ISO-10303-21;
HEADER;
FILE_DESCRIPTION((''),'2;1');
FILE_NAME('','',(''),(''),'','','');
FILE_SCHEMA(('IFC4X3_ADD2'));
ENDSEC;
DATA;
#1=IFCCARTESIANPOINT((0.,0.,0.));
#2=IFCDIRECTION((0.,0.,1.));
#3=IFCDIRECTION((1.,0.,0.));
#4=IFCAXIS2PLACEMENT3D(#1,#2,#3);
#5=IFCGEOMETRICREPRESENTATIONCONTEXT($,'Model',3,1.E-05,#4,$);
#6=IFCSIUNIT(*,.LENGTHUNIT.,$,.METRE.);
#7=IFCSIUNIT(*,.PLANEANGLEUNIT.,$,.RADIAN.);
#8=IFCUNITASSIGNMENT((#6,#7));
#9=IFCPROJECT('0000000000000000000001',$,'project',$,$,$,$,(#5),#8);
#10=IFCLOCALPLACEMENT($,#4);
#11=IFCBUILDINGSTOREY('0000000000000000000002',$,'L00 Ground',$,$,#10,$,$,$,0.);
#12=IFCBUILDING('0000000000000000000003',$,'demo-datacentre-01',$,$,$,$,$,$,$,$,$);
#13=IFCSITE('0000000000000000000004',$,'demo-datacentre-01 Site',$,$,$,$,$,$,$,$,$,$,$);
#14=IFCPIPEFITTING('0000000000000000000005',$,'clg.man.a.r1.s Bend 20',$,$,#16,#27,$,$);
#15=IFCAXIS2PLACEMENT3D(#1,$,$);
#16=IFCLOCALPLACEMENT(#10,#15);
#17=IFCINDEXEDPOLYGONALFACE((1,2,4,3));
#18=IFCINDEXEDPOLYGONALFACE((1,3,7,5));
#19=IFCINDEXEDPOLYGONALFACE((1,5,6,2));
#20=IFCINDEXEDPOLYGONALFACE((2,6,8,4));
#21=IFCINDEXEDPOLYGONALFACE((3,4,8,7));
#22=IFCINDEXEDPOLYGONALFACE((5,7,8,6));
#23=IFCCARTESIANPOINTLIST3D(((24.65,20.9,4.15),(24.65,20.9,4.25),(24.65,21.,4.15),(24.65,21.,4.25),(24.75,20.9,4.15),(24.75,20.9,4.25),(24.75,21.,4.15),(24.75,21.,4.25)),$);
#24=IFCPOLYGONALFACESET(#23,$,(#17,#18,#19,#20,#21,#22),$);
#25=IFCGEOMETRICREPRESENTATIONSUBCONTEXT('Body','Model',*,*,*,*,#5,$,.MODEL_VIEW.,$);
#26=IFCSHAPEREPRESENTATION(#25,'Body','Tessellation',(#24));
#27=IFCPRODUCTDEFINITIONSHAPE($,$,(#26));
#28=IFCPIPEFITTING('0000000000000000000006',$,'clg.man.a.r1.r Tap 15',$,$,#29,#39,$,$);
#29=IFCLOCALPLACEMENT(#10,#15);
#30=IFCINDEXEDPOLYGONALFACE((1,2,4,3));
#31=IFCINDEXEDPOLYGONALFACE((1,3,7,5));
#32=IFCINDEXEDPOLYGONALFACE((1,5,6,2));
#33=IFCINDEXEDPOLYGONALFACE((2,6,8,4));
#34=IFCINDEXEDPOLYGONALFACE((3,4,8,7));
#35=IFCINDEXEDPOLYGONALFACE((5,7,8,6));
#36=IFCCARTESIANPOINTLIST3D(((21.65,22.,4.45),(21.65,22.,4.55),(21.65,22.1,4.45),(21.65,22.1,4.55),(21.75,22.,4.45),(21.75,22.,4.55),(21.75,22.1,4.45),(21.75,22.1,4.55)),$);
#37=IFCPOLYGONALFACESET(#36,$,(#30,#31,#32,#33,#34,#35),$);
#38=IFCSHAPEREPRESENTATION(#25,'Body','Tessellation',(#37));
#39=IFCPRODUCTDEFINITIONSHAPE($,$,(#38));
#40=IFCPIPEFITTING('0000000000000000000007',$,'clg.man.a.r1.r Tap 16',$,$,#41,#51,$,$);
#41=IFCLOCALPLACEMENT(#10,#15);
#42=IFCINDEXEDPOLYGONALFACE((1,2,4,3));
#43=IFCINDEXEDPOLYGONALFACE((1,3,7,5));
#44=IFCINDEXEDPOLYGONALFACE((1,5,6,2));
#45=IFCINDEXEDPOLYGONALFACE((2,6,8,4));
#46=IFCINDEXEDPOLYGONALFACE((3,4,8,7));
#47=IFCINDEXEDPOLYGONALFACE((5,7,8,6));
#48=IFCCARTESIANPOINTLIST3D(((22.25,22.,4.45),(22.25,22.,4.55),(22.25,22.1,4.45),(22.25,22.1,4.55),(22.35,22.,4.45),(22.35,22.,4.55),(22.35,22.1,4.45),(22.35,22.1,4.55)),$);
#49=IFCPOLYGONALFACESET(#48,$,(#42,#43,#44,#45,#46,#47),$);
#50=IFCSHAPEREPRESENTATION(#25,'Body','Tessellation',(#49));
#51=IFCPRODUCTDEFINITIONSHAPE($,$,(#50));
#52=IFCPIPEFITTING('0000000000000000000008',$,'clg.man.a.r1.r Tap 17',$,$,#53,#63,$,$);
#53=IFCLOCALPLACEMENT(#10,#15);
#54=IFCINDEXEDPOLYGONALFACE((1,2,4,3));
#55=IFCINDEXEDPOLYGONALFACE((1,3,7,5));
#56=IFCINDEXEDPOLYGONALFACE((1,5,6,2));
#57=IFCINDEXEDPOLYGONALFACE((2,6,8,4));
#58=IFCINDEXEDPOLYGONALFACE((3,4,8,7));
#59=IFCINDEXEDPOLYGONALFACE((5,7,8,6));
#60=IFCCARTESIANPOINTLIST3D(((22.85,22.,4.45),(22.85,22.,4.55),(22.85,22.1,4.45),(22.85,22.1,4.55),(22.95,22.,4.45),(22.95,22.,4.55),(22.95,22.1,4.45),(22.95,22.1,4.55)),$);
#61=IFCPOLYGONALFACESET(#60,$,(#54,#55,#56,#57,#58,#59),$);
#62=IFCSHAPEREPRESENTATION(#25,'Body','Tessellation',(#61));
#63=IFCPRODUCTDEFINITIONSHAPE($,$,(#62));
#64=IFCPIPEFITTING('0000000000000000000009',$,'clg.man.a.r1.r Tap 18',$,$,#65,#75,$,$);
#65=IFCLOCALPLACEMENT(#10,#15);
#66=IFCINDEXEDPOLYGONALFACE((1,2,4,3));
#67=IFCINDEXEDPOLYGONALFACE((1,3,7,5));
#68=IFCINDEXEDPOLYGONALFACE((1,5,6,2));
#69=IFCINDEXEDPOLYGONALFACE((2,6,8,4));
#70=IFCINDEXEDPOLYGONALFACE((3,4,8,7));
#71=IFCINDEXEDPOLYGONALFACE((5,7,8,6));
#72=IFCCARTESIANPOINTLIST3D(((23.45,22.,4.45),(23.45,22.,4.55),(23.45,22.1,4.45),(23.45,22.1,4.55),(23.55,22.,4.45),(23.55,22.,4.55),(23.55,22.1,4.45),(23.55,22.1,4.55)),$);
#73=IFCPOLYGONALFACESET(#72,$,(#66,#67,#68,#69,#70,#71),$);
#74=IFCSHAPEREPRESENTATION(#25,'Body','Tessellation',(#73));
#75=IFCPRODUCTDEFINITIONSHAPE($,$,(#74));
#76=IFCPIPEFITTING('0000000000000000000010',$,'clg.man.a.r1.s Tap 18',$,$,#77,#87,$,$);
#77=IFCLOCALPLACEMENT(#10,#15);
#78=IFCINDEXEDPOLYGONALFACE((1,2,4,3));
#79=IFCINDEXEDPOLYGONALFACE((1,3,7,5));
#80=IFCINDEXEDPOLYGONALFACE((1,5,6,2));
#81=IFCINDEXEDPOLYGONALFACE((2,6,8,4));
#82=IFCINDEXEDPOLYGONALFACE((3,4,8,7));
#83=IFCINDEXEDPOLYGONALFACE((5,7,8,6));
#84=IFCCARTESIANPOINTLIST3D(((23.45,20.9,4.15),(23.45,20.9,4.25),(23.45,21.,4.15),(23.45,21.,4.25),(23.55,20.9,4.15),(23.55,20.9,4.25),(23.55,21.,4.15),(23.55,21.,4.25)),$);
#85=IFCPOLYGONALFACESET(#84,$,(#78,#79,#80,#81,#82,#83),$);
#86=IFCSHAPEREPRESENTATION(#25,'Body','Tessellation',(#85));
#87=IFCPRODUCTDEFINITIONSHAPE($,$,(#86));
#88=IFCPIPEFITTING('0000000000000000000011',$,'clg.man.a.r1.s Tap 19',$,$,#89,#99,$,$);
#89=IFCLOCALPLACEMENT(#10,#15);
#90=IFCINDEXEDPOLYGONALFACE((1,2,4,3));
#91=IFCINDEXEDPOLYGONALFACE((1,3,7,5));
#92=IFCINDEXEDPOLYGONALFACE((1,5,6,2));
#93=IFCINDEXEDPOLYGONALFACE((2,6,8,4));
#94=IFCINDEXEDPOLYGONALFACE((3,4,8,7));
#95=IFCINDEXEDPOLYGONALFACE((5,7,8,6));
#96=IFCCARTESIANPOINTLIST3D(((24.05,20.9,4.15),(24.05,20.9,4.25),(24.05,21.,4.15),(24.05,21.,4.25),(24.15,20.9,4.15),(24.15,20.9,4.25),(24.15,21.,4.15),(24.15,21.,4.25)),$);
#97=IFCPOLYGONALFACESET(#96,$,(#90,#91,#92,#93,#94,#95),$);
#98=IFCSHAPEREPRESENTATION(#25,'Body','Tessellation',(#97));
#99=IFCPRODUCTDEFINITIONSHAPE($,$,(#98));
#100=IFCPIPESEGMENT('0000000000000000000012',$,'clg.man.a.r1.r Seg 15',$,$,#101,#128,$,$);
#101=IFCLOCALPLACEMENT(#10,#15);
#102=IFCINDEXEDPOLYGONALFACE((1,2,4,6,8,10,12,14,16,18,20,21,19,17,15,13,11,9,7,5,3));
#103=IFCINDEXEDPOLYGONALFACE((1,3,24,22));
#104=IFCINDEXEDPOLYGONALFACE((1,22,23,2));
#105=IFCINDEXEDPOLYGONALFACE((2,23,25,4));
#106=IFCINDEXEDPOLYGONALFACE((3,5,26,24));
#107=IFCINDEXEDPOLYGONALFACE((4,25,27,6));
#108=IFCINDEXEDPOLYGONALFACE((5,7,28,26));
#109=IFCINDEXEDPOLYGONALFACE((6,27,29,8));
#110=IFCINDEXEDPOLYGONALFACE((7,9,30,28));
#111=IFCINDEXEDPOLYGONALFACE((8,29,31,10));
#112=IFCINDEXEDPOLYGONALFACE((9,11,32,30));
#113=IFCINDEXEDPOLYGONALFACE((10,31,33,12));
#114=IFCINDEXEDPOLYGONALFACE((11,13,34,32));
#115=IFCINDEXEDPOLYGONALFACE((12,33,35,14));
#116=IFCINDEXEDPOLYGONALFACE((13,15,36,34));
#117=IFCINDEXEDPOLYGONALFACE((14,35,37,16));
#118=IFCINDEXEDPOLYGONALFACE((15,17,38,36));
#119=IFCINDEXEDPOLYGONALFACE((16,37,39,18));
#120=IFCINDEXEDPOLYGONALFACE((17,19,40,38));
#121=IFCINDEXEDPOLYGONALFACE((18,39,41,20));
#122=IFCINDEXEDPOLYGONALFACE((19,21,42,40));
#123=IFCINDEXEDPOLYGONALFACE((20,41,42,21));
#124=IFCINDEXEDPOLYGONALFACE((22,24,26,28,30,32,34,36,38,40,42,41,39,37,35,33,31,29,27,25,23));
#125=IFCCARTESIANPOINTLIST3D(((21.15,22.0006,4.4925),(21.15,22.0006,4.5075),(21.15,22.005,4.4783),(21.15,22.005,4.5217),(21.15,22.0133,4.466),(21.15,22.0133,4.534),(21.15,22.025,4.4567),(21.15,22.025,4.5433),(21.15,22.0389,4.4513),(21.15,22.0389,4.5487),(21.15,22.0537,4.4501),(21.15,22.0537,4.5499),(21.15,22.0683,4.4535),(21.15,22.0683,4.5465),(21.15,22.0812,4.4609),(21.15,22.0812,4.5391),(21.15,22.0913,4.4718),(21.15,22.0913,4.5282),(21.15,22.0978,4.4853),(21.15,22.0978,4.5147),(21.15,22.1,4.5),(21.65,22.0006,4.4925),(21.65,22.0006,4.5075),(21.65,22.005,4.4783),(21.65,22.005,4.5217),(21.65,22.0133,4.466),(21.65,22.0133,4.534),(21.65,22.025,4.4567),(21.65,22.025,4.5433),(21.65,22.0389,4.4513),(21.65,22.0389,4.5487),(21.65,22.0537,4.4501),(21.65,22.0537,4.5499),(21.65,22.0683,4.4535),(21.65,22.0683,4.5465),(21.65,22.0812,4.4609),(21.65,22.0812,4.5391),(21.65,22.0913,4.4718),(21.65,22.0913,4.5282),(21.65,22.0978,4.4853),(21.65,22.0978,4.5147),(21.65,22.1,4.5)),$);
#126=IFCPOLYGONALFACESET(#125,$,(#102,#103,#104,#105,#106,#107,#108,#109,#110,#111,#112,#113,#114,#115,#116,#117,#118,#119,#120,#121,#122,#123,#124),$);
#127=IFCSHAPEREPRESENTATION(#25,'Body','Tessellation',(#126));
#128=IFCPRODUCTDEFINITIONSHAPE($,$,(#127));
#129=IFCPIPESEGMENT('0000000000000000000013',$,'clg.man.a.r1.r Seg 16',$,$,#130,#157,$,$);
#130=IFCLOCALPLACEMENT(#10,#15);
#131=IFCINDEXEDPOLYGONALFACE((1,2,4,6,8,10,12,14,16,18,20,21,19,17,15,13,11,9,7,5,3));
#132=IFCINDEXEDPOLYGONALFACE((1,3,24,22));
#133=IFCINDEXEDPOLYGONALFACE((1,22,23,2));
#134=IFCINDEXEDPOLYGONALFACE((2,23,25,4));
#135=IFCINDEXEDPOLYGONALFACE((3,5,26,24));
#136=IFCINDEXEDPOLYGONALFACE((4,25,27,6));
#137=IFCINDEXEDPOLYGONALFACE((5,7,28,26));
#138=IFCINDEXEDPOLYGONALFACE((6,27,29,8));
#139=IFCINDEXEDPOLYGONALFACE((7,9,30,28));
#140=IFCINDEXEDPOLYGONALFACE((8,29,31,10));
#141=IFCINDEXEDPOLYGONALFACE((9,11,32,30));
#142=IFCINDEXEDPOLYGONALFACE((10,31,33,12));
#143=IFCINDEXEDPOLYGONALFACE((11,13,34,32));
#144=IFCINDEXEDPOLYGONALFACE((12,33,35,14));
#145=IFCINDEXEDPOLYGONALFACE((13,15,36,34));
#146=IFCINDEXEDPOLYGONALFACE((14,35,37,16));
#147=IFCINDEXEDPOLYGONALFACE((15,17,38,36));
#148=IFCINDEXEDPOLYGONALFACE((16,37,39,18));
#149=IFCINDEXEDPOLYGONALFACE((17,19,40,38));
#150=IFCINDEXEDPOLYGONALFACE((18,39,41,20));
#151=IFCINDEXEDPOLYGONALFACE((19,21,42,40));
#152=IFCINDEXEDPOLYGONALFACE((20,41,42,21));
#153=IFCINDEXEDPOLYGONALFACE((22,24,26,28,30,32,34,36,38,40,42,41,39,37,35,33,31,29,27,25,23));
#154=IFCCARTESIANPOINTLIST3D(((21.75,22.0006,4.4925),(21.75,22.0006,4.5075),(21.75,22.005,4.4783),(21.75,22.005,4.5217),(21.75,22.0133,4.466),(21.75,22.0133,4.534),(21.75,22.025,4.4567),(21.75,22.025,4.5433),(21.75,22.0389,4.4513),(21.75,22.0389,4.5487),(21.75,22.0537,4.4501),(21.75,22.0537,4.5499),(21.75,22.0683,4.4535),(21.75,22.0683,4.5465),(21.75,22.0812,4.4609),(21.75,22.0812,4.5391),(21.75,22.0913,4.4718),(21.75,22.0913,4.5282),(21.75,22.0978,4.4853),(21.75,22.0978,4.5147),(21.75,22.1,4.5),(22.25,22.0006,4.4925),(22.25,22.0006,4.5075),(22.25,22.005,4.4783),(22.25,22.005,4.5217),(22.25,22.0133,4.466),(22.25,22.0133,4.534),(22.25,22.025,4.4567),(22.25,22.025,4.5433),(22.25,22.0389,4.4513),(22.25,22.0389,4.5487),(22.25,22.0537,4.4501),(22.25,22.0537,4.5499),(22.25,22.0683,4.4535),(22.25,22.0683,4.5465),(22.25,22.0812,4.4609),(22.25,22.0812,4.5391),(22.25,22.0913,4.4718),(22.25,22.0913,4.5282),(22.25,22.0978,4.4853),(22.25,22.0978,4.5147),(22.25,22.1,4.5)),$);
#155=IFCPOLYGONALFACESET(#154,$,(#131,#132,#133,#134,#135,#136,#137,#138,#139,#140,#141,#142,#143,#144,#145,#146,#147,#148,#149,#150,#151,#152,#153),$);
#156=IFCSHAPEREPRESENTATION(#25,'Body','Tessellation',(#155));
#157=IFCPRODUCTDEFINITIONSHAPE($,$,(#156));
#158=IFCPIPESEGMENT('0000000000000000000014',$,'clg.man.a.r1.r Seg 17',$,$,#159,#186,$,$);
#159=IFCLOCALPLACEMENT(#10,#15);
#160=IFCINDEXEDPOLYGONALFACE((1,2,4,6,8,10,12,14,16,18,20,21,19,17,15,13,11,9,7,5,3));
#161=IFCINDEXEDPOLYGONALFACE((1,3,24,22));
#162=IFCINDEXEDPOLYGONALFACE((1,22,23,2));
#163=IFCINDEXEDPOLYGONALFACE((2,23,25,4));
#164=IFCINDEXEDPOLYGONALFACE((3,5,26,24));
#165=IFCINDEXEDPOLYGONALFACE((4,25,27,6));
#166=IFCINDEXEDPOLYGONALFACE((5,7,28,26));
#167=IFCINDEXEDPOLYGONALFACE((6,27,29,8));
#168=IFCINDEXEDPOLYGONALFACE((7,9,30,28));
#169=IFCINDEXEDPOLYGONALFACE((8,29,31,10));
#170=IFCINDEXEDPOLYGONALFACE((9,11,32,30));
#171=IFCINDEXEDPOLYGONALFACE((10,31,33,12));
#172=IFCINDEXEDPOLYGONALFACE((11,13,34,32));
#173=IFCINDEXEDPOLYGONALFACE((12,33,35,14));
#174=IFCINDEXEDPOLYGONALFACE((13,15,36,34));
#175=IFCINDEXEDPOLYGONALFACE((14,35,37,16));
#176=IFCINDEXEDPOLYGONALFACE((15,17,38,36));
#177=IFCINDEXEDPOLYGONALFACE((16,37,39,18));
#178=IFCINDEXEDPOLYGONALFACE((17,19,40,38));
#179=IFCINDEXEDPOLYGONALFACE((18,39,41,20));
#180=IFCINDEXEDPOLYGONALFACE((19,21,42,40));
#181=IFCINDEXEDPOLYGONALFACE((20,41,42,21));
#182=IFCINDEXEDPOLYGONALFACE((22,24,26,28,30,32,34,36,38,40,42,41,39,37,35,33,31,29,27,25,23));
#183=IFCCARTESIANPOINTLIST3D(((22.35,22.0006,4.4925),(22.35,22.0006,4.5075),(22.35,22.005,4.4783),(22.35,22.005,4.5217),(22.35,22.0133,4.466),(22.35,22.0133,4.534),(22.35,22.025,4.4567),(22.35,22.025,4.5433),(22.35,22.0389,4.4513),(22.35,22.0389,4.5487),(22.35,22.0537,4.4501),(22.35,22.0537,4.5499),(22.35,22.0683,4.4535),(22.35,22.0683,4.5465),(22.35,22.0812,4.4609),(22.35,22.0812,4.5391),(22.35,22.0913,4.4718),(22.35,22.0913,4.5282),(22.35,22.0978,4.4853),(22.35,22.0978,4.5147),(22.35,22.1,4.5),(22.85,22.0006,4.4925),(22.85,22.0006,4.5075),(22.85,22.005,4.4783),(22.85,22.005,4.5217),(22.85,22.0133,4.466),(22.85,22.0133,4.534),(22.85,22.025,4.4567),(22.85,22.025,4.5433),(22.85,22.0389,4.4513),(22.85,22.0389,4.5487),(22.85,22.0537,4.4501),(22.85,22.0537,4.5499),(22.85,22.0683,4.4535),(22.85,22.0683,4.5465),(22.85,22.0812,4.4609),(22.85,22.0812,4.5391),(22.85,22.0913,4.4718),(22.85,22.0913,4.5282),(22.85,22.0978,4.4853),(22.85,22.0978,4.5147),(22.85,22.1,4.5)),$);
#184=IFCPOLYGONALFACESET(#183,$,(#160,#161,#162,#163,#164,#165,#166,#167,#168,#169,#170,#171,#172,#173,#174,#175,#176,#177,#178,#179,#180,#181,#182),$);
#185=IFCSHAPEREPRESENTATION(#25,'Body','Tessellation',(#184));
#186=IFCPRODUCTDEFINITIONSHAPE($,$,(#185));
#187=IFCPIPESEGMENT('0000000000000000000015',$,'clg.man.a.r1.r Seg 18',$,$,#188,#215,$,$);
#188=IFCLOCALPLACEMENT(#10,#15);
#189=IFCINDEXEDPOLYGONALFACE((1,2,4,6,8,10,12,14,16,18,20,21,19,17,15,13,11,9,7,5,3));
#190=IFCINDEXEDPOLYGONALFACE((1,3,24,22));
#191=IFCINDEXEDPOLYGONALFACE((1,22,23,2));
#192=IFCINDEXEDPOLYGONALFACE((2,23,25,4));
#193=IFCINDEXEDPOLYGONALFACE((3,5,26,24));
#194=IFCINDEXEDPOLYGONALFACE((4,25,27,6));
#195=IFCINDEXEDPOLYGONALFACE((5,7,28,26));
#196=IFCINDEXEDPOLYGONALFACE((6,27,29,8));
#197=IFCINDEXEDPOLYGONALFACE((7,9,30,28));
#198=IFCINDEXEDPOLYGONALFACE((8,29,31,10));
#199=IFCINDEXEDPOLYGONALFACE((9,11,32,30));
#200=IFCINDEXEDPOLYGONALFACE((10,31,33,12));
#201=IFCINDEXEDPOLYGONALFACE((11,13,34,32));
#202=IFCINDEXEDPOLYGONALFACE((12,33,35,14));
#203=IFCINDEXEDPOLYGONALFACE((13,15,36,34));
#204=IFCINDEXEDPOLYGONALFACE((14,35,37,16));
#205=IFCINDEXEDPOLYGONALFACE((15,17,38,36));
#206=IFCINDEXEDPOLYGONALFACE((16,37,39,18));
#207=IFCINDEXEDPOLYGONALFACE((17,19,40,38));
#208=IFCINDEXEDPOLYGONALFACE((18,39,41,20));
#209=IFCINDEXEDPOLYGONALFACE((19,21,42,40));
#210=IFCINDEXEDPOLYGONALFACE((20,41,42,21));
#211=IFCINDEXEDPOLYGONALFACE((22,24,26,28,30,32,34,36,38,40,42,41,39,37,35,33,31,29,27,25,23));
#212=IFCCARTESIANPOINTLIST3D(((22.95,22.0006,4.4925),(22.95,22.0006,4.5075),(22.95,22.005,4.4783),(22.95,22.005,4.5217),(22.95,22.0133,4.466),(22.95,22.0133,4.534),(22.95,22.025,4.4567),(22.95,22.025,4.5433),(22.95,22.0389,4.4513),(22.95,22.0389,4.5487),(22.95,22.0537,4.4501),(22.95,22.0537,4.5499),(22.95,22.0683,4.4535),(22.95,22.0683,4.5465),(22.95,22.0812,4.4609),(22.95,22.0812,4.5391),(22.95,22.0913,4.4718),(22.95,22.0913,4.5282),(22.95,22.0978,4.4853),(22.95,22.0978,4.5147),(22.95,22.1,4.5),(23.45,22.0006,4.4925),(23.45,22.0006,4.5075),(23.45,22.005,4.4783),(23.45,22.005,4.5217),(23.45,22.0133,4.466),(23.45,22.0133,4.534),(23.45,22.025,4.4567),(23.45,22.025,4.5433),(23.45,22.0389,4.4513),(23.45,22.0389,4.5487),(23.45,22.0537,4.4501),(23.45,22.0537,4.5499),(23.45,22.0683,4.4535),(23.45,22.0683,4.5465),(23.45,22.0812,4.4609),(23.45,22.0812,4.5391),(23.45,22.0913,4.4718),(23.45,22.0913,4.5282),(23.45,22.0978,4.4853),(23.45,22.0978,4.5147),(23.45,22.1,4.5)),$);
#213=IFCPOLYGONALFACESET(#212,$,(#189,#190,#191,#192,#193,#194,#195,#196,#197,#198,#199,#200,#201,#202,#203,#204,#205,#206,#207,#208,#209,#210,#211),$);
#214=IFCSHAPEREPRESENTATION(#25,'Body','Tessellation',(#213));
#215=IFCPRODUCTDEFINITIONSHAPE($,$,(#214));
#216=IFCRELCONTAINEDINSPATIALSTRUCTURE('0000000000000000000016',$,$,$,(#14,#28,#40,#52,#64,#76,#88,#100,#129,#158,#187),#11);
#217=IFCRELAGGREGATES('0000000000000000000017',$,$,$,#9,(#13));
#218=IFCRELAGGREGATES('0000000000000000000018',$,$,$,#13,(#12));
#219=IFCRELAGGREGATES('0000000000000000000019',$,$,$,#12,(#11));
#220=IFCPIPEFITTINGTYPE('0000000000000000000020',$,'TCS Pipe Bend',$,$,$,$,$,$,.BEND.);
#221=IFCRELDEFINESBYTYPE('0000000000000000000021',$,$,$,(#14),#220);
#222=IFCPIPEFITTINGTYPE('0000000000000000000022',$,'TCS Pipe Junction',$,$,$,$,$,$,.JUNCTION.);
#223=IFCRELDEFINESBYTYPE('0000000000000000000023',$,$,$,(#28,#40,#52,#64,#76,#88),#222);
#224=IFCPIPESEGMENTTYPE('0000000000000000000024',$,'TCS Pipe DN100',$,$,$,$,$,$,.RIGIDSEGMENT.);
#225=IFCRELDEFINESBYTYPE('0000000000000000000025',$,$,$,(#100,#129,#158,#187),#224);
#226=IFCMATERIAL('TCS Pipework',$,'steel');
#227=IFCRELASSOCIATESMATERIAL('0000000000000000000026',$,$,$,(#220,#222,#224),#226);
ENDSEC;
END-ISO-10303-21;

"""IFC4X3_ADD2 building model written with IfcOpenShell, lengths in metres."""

from ifc_helpers import new_model, si_unit, frame, origin_with_axes, place, context, subcontext, project, spatial, rectangle, circle, extrude, material, type_object, element, save


model = new_model("IFC4X3_ADD2")

# Units and contexts
model_context = context("Model", 3, precision=1e-05, world=origin_with_axes())
body_context = subcontext(model_context, "Body", "Model", "MODEL_VIEW")
ifc_project = project(units=[si_unit("LENGTHUNIT", "METRE"), si_unit("PLANEANGLEUNIT", "RADIAN")], contexts=[model_context])

# Site, building, storey
site = spatial("IfcSite", under=ifc_project, Name="demo-datacentre-01 Site")
building = spatial("IfcBuilding", under=site, Name="demo-datacentre-01")
storey_placement = place(None, origin_with_axes())
storey = spatial("IfcBuildingStorey", under=building, at=storey_placement, Name="L00 Ground", Elevation=0.0)

# Pipe fittings
ifc_material = material(Name="TCS Pipework", Category="steel")
pipe_fitting_type_1 = type_object("IfcPipeFittingType", Name="TCS Pipe Bend", PredefinedType="BEND", material=ifc_material)
pipe_fitting_placement = place(storey_placement, frame((24.7, 20.95, 4.15), z_axis=(0.0, 0.0, 1.0), x_axis=(1.0, 0.0, 0.0)))
element("IfcPipeFitting", 1, at=pipe_fitting_placement, inside=storey, type_object=pipe_fitting_type_1, Name="clg.man.a.r1.s Bend 20", context=body_context, shape_type="SweptSolid", body=[
    extrude(rectangle(XDim=0.1, YDim=0.1), origin_with_axes(), (0.0, 0.0, 1.0), 0.1),
])
pipe_fitting_type_2 = type_object("IfcPipeFittingType", Name="TCS Pipe Junction", PredefinedType="JUNCTION", material=ifc_material)
for number, where, z_axis, x_axis, name in (
    (2, (21.7, 22.05, 4.45), (0.0, 0.0, 1.0), (1.0, 0.0, 0.0), "clg.man.a.r1.r Tap 15"),
    (3, (22.3, 22.05, 4.45), (0.0, 0.0, 1.0), (1.0, 0.0, 0.0), "clg.man.a.r1.r Tap 16"),
    (4, (22.9, 22.05, 4.45), (0.0, 0.0, 1.0), (1.0, 0.0, 0.0), "clg.man.a.r1.r Tap 17"),
    (5, (23.5, 22.05, 4.45), (0.0, 0.0, 1.0), (1.0, 0.0, 0.0), "clg.man.a.r1.r Tap 18"),
    (6, (23.5, 20.95, 4.15), (0.0, 0.0, 1.0), (1.0, 0.0, 0.0), "clg.man.a.r1.s Tap 18"),
    (7, (24.1, 20.95, 4.15), (0.0, 0.0, 1.0), (1.0, 0.0, 0.0), "clg.man.a.r1.s Tap 19"),
):
    element("IfcPipeFitting", number, at=place(storey_placement, frame(where, z_axis=z_axis, x_axis=x_axis)), inside=storey, type_object=pipe_fitting_type_2, Name=name, context=body_context, shape_type="SweptSolid", body=[
        extrude(rectangle(XDim=0.1, YDim=0.1), origin_with_axes(), (0.0, 0.0, 1.0), 0.1),
    ])

# Pipe segments
pipe_segment_type_1 = type_object("IfcPipeSegmentType", Name="TCS Pipe DN100", PredefinedType="RIGIDSEGMENT", material=ifc_material)
pipe_segment_placement = place(storey_placement, frame((21.15, 22.05, 4.5), z_axis=(1.0, 0.0, 0.0), x_axis=(0.0, 1.0, 0.0)))
element("IfcPipeSegment", 8, at=pipe_segment_placement, inside=storey, type_object=pipe_segment_type_1, Name="clg.man.a.r1.r Seg 15", context=body_context, shape_type="SweptSolid", body=[
    extrude(circle(Radius=0.05), origin_with_axes(), (0.0, 0.0, 1.0), 0.5),
])
for number, where, z_axis, x_axis, name in (
    (9, (21.75, 22.05, 4.5), (1.0, 0.0, 0.0), (0.0, 1.0, 0.0), "clg.man.a.r1.r Seg 16"),
    (10, (22.35, 22.05, 4.5), (1.0, 0.0, 0.0), (0.0, 1.0, 0.0), "clg.man.a.r1.r Seg 17"),
):
    element("IfcPipeSegment", number, at=place(storey_placement, frame(where, z_axis=z_axis, x_axis=x_axis)), inside=storey, type_object=pipe_segment_type_1, Name=name, context=body_context, shape_type="SweptSolid", body=[
        extrude(circle(Radius=0.05), origin_with_axes(), (0.0, 0.0, 1.0), 0.5),
    ])
for number, where, z_axis, x_axis, name in (
    (11, (22.95, 22.05, 4.5), (1.0, 0.0, 0.0), (0.0, 1.0, 0.0), "clg.man.a.r1.r Seg 18"),
):
    element("IfcPipeSegment", number, at=place(storey_placement, frame(where, z_axis=z_axis, x_axis=x_axis)), inside=storey, type_object=pipe_segment_type_1, Name=name, context=body_context, shape_type="SweptSolid", body=[
        extrude(circle(Radius=0.05), origin_with_axes(), (0.0, 0.0, 1.0), 0.5),
    ])

save(model, "model.ifc")
